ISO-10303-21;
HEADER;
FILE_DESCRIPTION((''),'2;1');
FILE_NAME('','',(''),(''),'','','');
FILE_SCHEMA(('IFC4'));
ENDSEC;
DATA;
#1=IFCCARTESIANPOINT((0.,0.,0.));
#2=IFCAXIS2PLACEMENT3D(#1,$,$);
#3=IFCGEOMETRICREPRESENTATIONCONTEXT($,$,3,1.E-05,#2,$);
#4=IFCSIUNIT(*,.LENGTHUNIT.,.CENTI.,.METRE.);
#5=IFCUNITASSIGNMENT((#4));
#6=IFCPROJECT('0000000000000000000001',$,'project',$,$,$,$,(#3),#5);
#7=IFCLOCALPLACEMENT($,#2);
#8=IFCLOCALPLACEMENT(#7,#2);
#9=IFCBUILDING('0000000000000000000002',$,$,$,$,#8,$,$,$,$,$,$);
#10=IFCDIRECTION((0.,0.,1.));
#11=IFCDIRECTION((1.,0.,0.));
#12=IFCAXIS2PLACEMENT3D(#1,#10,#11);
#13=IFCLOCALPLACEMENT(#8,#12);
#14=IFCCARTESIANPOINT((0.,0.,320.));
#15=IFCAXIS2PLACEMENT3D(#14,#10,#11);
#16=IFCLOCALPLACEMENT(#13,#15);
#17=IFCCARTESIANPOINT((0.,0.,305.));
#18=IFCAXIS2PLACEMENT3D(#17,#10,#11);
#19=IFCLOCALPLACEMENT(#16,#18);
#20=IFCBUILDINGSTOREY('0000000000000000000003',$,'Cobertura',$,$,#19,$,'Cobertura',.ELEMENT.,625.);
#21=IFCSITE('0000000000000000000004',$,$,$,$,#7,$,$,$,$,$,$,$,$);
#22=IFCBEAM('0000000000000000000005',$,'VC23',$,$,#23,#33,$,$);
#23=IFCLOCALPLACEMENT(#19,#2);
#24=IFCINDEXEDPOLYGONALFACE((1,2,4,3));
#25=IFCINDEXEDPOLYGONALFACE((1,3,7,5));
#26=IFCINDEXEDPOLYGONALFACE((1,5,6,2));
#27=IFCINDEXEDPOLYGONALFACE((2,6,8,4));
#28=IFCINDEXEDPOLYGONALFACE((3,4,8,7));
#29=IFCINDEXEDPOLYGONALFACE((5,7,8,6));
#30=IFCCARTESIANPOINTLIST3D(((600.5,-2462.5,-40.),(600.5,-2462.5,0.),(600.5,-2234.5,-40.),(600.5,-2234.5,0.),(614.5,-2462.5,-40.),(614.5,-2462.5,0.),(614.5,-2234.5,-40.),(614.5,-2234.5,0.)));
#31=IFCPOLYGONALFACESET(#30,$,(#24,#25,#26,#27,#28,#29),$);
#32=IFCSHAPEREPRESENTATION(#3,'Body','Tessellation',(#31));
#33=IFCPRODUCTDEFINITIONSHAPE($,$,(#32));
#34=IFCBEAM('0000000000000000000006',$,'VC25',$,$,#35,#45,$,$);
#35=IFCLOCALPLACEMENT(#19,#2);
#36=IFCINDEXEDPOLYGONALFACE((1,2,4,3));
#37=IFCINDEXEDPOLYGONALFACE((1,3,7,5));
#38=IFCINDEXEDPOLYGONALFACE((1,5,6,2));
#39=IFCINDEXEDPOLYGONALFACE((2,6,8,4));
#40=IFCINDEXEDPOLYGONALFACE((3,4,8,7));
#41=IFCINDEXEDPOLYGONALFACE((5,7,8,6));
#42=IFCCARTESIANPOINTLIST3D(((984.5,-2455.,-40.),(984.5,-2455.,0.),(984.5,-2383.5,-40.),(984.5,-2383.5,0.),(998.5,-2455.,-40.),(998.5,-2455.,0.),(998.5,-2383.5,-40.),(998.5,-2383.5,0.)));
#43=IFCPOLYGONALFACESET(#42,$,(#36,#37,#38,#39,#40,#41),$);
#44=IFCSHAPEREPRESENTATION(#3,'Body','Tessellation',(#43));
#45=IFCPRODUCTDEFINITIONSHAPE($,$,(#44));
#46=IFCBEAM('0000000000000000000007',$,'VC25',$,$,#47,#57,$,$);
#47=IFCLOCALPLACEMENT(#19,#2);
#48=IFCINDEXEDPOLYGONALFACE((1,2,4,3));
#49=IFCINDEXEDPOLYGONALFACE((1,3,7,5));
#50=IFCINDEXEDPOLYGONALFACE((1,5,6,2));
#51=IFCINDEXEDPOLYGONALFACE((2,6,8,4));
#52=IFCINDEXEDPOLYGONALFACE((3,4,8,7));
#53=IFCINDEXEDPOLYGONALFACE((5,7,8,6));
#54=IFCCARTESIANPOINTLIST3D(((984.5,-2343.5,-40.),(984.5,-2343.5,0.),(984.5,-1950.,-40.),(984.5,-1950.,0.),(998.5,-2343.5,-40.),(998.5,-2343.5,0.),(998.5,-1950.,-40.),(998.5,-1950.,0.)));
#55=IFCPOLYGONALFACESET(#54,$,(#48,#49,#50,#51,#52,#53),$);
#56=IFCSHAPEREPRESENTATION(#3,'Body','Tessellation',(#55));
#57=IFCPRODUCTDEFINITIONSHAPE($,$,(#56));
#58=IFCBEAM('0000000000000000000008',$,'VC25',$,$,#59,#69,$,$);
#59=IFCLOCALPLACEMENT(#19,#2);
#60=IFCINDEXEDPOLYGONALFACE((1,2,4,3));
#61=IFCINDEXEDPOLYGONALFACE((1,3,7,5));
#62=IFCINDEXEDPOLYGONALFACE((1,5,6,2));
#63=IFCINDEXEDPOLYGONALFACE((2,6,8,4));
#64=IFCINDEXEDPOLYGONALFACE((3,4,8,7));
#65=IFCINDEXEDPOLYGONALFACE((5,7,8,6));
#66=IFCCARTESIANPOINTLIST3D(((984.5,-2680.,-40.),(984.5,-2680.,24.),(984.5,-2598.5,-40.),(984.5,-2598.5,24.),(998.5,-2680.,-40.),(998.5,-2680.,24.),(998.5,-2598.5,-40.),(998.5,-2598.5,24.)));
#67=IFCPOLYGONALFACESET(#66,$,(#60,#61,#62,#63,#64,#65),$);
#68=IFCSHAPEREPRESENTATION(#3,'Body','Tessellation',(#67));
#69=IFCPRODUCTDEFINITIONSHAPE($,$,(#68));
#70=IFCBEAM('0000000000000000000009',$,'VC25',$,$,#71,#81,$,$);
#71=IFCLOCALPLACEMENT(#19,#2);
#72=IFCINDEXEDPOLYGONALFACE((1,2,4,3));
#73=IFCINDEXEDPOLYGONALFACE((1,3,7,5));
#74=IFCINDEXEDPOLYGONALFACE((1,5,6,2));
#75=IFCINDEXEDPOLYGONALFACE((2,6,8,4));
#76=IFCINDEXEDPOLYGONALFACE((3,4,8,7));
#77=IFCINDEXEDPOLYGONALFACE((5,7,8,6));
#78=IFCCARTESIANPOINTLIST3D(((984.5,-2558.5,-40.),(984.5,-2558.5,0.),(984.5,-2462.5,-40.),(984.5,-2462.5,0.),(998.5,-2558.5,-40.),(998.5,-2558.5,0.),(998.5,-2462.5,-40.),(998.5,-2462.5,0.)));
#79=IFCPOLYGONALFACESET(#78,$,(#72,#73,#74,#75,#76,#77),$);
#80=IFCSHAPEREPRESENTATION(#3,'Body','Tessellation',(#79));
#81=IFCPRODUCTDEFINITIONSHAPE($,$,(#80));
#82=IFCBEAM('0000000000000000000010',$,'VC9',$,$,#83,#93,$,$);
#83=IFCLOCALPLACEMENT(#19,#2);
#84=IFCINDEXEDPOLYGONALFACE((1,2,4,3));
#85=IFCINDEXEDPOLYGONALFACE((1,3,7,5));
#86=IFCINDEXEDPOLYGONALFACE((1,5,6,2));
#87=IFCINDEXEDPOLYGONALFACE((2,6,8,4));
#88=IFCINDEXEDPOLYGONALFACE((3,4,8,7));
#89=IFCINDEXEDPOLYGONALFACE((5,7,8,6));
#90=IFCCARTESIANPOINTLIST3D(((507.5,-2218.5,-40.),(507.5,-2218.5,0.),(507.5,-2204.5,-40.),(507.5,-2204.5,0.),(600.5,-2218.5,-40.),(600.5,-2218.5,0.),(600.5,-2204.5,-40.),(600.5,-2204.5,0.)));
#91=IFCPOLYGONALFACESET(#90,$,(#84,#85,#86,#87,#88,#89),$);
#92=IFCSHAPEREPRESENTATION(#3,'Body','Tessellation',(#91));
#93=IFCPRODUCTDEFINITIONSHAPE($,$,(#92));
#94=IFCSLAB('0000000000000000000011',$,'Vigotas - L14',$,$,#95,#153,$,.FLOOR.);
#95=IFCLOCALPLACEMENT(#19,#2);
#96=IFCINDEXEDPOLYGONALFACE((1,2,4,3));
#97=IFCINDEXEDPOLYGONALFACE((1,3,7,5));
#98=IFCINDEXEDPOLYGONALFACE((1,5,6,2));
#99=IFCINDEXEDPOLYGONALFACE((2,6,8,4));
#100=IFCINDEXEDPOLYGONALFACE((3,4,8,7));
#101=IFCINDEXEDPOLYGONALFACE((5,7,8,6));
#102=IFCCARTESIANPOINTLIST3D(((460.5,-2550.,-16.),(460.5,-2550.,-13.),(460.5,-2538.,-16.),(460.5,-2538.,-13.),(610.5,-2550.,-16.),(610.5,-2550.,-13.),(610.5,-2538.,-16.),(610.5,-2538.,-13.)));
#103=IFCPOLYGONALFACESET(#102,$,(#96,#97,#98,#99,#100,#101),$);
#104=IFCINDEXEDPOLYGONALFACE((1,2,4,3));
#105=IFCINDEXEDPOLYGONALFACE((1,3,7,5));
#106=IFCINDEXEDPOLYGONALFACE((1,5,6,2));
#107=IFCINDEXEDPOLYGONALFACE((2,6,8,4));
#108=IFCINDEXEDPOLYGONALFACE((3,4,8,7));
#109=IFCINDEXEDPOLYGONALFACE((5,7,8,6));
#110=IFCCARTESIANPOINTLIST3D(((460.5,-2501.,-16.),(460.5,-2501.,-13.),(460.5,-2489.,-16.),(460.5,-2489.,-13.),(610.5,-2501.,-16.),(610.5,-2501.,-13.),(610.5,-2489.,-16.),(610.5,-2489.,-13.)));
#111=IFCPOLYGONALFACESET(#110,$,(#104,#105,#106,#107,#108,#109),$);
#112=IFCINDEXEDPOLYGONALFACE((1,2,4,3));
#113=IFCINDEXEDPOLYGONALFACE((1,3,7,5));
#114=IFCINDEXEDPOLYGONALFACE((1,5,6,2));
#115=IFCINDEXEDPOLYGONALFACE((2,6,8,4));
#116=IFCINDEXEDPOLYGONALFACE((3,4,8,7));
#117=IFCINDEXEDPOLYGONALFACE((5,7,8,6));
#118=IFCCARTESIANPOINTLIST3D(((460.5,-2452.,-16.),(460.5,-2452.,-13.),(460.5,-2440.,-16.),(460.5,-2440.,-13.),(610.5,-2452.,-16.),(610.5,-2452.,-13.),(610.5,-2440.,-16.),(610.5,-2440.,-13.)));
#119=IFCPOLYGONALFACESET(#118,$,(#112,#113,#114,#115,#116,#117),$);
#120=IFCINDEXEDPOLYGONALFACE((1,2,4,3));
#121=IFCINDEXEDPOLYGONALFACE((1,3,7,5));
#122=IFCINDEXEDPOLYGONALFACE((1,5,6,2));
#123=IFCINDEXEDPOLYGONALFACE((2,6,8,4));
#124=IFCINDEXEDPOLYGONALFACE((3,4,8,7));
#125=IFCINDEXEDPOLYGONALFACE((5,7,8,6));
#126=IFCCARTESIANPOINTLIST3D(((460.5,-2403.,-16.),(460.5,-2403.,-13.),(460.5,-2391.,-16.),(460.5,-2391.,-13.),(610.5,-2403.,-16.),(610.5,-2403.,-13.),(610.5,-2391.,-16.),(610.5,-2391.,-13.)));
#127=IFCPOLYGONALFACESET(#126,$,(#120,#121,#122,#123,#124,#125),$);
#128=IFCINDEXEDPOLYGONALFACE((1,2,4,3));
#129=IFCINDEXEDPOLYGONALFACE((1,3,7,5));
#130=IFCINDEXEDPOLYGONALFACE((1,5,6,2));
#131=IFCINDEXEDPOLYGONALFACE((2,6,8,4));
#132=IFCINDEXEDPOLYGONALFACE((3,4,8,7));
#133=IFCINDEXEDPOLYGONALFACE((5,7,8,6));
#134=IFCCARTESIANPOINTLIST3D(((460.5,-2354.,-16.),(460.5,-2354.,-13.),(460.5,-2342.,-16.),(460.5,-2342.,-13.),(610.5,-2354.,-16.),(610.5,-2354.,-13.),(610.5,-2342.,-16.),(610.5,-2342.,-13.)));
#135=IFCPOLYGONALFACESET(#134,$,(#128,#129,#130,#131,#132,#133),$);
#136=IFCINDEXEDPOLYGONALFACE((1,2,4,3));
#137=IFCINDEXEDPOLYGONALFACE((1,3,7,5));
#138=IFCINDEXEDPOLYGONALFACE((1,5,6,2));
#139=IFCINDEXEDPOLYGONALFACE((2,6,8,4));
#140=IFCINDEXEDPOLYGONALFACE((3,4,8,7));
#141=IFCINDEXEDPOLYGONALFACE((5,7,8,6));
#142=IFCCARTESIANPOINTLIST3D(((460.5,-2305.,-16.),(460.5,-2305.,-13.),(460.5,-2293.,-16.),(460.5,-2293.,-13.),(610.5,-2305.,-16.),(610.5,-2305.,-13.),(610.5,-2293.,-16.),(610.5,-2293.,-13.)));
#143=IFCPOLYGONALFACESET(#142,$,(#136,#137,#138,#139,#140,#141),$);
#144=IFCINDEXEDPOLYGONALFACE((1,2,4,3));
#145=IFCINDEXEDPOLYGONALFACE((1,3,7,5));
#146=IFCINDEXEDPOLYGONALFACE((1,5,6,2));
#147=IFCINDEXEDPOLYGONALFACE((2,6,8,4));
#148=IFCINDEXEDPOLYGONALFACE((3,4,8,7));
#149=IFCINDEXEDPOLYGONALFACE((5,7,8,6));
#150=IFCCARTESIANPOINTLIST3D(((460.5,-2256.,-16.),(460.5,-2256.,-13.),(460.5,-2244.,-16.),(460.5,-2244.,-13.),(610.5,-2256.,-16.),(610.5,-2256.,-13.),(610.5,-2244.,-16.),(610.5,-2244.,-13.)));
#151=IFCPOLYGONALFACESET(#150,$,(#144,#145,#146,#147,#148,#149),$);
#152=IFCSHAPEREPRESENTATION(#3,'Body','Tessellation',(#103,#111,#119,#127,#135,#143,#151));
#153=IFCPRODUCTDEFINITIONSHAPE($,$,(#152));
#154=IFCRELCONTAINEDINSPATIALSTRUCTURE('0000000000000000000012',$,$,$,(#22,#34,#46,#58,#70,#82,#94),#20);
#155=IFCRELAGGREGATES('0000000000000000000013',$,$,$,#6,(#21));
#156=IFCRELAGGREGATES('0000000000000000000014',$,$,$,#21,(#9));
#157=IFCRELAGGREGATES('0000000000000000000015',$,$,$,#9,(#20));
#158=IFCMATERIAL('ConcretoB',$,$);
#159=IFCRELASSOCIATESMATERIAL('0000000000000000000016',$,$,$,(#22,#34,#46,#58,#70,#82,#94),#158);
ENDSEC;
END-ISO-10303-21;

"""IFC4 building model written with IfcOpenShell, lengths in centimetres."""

from ifc_helpers import new_model, si_unit, frame, origin, origin_with_axes, place, context, project, spatial, polyline, outline, extrude, material, element, save


model = new_model("IFC4")

# Units and contexts
context_of_model = context(None, 3, precision=1e-05, world=origin())
ifc_project = project(units=[si_unit("LENGTHUNIT", "METRE", prefix="CENTI")], contexts=[context_of_model])

# Site, building, storey
site_placement = place(None, origin())
site = spatial("IfcSite", under=ifc_project, at=site_placement)
building_placement = place(site_placement, origin())
building = spatial("IfcBuilding", under=site, at=building_placement)
placement_1 = place(building_placement, origin_with_axes())
placement_2 = place(placement_1, frame((0.0, 0.0, 320.0), z_axis=(0.0, 0.0, 1.0), x_axis=(1.0, 0.0, 0.0)))
storey_placement = place(placement_2, frame((0.0, 0.0, 305.0), z_axis=(0.0, 0.0, 1.0), x_axis=(1.0, 0.0, 0.0)))
storey = spatial("IfcBuildingStorey", under=building, at=storey_placement, Name="Cobertura", LongName="Cobertura", CompositionType="ELEMENT", Elevation=625.0)

# Shared definitions
ifc_material = material(Name="ConcretoB")

# Beams
beam_1_placement = place(storey_placement, frame((607.5, -2348.5, 0.0), z_axis=(0.0, 0.0, 1.0), x_axis=(1.0, 0.0, 0.0)))
element("IfcBeam", 1, at=beam_1_placement, inside=storey, material=ifc_material, Name="VC23", context=context_of_model, shape_type="SolidModel", body=[
    extrude(outline(polyline([(-7.0, -20.0), (7.0, -20.0), (7.0, 20.0), (-7.0, 20.0), (-7.0, -20.0)])), frame((0.0, -114.0, -20.0), z_axis=(0.0, 1.0, 0.0), x_axis=(1.0, 0.0, 0.0)), (0.0, 0.0, 1.0), 228.0),
])
beam_2_placement = place(storey_placement, frame((991.5, -2419.25, 0.0), z_axis=(0.0, 0.0, 1.0), x_axis=(1.0, 0.0, 0.0)))
element("IfcBeam", 2, at=beam_2_placement, inside=storey, material=ifc_material, Name="VC25", context=context_of_model, shape_type="SolidModel", body=[
    extrude(outline(polyline([(-7.0, -20.0), (7.0, -20.0), (7.0, 20.0), (-7.0, 20.0), (-7.0, -20.0)])), frame((0.0, -35.75, -20.0), z_axis=(0.0, 1.0, 0.0), x_axis=(1.0, 0.0, 0.0)), (0.0, 0.0, 1.0), 71.5),
])
beam_3_placement = place(storey_placement, frame((991.5, -2146.75, 0.0), z_axis=(0.0, 0.0, 1.0), x_axis=(1.0, 0.0, 0.0)))
element("IfcBeam", 3, at=beam_3_placement, inside=storey, material=ifc_material, Name="VC25", context=context_of_model, shape_type="SolidModel", body=[
    extrude(outline(polyline([(-7.0, -20.0), (7.0, -20.0), (7.0, 20.0), (-7.0, 20.0), (-7.0, -20.0)])), frame((0.0, -196.75, -20.0), z_axis=(0.0, 1.0, 0.0), x_axis=(1.0, 0.0, 0.0)), (0.0, 0.0, 1.0), 393.5),
])
beam_4_placement = place(storey_placement, frame((991.5, -2639.25, 24.0), z_axis=(0.0, 0.0, 1.0), x_axis=(1.0, 0.0, 0.0)))
element("IfcBeam", 4, at=beam_4_placement, inside=storey, material=ifc_material, Name="VC25", context=context_of_model, shape_type="SolidModel", body=[
    extrude(outline(polyline([(-7.0, -32.0), (7.0, -32.0), (7.0, 32.0), (-7.0, 32.0), (-7.0, -32.0)])), frame((0.0, -40.75, -32.0), z_axis=(0.0, 1.0, 0.0), x_axis=(1.0, 0.0, 0.0)), (0.0, 0.0, 1.0), 81.5),
])
beam_5_placement = place(storey_placement, frame((991.5, -2510.5, 0.0), z_axis=(0.0, 0.0, 1.0), x_axis=(1.0, 0.0, 0.0)))
element("IfcBeam", 5, at=beam_5_placement, inside=storey, material=ifc_material, Name="VC25", context=context_of_model, shape_type="SolidModel", body=[
    extrude(outline(polyline([(-7.0, -20.0), (7.0, -20.0), (7.0, 20.0), (-7.0, 20.0), (-7.0, -20.0)])), frame((0.0, -48.0, -20.0), z_axis=(0.0, 1.0, 0.0), x_axis=(1.0, 0.0, 0.0)), (0.0, 0.0, 1.0), 96.0),
])
beam_6_placement = place(storey_placement, frame((554.0, -2211.5, 0.0), z_axis=(0.0, 0.0, 1.0), x_axis=(1.0, 0.0, 0.0)))
element("IfcBeam", 6, at=beam_6_placement, inside=storey, material=ifc_material, Name="VC9", context=context_of_model, shape_type="SolidModel", body=[
    extrude(outline(polyline([(-7.0, -20.0), (7.0, -20.0), (7.0, 20.0), (-7.0, 20.0), (-7.0, -20.0)])), frame((-46.5, 0.0, -20.0), z_axis=(1.0, 0.0, 0.0), x_axis=(0.0, -1.0, 0.0)), (0.0, 0.0, 1.0), 93.0),
])

# Slab
slab_1_placement = place(storey_placement, frame((535.5, -2397.0, -13.0), z_axis=(0.0, 0.0, 1.0), x_axis=(1.0, 0.0, 0.0)))
element("IfcSlab", 7, at=slab_1_placement, inside=storey, material=ifc_material, Name="Vigotas - L14", PredefinedType="FLOOR", context=context_of_model, shape_type="SolidModel", body=[
    extrude(outline(polyline([(6.0, 1.5), (-6.0, 1.5), (-6.0, -1.5), (6.0, -1.5), (6.0, 1.5), (6.0, 1.5)])), frame((-75.0, -147.0, -1.5), z_axis=(1.0, 0.0, 0.0), x_axis=(0.0, -1.0, 0.0)), (0.0, 0.0, 1.0), 150.0),
    extrude(outline(polyline([(6.0, 1.5), (-6.0, 1.5), (-6.0, -1.5), (6.0, -1.5), (6.0, 1.5), (6.0, 1.5)])), frame((-75.0, -98.0, -1.5), z_axis=(1.0, 0.0, 0.0), x_axis=(0.0, -1.0, 0.0)), (0.0, 0.0, 1.0), 150.0),
    extrude(outline(polyline([(6.0, 1.5), (-6.0, 1.5), (-6.0, -1.5), (6.0, -1.5), (6.0, 1.5), (6.0, 1.5)])), frame((-75.0, -49.0, -1.5), z_axis=(1.0, 0.0, 0.0), x_axis=(0.0, -1.0, 0.0)), (0.0, 0.0, 1.0), 150.0),
    extrude(outline(polyline([(6.0, 1.5), (-6.0, 1.5), (-6.0, -1.5), (6.0, -1.5), (6.0, 1.5), (6.0, 1.5)])), frame((-75.0, 0.0, -1.5), z_axis=(1.0, 0.0, 0.0), x_axis=(0.0, -1.0, 0.0)), (0.0, 0.0, 1.0), 150.0),
    extrude(outline(polyline([(6.0, 1.5), (-6.0, 1.5), (-6.0, -1.5), (6.0, -1.5), (6.0, 1.5), (6.0, 1.5)])), frame((-75.0, 49.0, -1.5), z_axis=(1.0, 0.0, 0.0), x_axis=(0.0, -1.0, 0.0)), (0.0, 0.0, 1.0), 150.0),
    extrude(outline(polyline([(6.0, 1.5), (-6.0, 1.5), (-6.0, -1.5), (6.0, -1.5), (6.0, 1.5), (6.0, 1.5)])), frame((-75.0, 98.0, -1.5), z_axis=(1.0, 0.0, 0.0), x_axis=(0.0, -1.0, 0.0)), (0.0, 0.0, 1.0), 150.0),
    extrude(outline(polyline([(6.0, 1.5), (-6.0, 1.5), (-6.0, -1.5), (6.0, -1.5), (6.0, 1.5), (6.0, 1.5)])), frame((-75.0, 147.0, -1.5), z_axis=(1.0, 0.0, 0.0), x_axis=(0.0, -1.0, 0.0)), (0.0, 0.0, 1.0), 150.0),
])

save(model, "model.ifc")
